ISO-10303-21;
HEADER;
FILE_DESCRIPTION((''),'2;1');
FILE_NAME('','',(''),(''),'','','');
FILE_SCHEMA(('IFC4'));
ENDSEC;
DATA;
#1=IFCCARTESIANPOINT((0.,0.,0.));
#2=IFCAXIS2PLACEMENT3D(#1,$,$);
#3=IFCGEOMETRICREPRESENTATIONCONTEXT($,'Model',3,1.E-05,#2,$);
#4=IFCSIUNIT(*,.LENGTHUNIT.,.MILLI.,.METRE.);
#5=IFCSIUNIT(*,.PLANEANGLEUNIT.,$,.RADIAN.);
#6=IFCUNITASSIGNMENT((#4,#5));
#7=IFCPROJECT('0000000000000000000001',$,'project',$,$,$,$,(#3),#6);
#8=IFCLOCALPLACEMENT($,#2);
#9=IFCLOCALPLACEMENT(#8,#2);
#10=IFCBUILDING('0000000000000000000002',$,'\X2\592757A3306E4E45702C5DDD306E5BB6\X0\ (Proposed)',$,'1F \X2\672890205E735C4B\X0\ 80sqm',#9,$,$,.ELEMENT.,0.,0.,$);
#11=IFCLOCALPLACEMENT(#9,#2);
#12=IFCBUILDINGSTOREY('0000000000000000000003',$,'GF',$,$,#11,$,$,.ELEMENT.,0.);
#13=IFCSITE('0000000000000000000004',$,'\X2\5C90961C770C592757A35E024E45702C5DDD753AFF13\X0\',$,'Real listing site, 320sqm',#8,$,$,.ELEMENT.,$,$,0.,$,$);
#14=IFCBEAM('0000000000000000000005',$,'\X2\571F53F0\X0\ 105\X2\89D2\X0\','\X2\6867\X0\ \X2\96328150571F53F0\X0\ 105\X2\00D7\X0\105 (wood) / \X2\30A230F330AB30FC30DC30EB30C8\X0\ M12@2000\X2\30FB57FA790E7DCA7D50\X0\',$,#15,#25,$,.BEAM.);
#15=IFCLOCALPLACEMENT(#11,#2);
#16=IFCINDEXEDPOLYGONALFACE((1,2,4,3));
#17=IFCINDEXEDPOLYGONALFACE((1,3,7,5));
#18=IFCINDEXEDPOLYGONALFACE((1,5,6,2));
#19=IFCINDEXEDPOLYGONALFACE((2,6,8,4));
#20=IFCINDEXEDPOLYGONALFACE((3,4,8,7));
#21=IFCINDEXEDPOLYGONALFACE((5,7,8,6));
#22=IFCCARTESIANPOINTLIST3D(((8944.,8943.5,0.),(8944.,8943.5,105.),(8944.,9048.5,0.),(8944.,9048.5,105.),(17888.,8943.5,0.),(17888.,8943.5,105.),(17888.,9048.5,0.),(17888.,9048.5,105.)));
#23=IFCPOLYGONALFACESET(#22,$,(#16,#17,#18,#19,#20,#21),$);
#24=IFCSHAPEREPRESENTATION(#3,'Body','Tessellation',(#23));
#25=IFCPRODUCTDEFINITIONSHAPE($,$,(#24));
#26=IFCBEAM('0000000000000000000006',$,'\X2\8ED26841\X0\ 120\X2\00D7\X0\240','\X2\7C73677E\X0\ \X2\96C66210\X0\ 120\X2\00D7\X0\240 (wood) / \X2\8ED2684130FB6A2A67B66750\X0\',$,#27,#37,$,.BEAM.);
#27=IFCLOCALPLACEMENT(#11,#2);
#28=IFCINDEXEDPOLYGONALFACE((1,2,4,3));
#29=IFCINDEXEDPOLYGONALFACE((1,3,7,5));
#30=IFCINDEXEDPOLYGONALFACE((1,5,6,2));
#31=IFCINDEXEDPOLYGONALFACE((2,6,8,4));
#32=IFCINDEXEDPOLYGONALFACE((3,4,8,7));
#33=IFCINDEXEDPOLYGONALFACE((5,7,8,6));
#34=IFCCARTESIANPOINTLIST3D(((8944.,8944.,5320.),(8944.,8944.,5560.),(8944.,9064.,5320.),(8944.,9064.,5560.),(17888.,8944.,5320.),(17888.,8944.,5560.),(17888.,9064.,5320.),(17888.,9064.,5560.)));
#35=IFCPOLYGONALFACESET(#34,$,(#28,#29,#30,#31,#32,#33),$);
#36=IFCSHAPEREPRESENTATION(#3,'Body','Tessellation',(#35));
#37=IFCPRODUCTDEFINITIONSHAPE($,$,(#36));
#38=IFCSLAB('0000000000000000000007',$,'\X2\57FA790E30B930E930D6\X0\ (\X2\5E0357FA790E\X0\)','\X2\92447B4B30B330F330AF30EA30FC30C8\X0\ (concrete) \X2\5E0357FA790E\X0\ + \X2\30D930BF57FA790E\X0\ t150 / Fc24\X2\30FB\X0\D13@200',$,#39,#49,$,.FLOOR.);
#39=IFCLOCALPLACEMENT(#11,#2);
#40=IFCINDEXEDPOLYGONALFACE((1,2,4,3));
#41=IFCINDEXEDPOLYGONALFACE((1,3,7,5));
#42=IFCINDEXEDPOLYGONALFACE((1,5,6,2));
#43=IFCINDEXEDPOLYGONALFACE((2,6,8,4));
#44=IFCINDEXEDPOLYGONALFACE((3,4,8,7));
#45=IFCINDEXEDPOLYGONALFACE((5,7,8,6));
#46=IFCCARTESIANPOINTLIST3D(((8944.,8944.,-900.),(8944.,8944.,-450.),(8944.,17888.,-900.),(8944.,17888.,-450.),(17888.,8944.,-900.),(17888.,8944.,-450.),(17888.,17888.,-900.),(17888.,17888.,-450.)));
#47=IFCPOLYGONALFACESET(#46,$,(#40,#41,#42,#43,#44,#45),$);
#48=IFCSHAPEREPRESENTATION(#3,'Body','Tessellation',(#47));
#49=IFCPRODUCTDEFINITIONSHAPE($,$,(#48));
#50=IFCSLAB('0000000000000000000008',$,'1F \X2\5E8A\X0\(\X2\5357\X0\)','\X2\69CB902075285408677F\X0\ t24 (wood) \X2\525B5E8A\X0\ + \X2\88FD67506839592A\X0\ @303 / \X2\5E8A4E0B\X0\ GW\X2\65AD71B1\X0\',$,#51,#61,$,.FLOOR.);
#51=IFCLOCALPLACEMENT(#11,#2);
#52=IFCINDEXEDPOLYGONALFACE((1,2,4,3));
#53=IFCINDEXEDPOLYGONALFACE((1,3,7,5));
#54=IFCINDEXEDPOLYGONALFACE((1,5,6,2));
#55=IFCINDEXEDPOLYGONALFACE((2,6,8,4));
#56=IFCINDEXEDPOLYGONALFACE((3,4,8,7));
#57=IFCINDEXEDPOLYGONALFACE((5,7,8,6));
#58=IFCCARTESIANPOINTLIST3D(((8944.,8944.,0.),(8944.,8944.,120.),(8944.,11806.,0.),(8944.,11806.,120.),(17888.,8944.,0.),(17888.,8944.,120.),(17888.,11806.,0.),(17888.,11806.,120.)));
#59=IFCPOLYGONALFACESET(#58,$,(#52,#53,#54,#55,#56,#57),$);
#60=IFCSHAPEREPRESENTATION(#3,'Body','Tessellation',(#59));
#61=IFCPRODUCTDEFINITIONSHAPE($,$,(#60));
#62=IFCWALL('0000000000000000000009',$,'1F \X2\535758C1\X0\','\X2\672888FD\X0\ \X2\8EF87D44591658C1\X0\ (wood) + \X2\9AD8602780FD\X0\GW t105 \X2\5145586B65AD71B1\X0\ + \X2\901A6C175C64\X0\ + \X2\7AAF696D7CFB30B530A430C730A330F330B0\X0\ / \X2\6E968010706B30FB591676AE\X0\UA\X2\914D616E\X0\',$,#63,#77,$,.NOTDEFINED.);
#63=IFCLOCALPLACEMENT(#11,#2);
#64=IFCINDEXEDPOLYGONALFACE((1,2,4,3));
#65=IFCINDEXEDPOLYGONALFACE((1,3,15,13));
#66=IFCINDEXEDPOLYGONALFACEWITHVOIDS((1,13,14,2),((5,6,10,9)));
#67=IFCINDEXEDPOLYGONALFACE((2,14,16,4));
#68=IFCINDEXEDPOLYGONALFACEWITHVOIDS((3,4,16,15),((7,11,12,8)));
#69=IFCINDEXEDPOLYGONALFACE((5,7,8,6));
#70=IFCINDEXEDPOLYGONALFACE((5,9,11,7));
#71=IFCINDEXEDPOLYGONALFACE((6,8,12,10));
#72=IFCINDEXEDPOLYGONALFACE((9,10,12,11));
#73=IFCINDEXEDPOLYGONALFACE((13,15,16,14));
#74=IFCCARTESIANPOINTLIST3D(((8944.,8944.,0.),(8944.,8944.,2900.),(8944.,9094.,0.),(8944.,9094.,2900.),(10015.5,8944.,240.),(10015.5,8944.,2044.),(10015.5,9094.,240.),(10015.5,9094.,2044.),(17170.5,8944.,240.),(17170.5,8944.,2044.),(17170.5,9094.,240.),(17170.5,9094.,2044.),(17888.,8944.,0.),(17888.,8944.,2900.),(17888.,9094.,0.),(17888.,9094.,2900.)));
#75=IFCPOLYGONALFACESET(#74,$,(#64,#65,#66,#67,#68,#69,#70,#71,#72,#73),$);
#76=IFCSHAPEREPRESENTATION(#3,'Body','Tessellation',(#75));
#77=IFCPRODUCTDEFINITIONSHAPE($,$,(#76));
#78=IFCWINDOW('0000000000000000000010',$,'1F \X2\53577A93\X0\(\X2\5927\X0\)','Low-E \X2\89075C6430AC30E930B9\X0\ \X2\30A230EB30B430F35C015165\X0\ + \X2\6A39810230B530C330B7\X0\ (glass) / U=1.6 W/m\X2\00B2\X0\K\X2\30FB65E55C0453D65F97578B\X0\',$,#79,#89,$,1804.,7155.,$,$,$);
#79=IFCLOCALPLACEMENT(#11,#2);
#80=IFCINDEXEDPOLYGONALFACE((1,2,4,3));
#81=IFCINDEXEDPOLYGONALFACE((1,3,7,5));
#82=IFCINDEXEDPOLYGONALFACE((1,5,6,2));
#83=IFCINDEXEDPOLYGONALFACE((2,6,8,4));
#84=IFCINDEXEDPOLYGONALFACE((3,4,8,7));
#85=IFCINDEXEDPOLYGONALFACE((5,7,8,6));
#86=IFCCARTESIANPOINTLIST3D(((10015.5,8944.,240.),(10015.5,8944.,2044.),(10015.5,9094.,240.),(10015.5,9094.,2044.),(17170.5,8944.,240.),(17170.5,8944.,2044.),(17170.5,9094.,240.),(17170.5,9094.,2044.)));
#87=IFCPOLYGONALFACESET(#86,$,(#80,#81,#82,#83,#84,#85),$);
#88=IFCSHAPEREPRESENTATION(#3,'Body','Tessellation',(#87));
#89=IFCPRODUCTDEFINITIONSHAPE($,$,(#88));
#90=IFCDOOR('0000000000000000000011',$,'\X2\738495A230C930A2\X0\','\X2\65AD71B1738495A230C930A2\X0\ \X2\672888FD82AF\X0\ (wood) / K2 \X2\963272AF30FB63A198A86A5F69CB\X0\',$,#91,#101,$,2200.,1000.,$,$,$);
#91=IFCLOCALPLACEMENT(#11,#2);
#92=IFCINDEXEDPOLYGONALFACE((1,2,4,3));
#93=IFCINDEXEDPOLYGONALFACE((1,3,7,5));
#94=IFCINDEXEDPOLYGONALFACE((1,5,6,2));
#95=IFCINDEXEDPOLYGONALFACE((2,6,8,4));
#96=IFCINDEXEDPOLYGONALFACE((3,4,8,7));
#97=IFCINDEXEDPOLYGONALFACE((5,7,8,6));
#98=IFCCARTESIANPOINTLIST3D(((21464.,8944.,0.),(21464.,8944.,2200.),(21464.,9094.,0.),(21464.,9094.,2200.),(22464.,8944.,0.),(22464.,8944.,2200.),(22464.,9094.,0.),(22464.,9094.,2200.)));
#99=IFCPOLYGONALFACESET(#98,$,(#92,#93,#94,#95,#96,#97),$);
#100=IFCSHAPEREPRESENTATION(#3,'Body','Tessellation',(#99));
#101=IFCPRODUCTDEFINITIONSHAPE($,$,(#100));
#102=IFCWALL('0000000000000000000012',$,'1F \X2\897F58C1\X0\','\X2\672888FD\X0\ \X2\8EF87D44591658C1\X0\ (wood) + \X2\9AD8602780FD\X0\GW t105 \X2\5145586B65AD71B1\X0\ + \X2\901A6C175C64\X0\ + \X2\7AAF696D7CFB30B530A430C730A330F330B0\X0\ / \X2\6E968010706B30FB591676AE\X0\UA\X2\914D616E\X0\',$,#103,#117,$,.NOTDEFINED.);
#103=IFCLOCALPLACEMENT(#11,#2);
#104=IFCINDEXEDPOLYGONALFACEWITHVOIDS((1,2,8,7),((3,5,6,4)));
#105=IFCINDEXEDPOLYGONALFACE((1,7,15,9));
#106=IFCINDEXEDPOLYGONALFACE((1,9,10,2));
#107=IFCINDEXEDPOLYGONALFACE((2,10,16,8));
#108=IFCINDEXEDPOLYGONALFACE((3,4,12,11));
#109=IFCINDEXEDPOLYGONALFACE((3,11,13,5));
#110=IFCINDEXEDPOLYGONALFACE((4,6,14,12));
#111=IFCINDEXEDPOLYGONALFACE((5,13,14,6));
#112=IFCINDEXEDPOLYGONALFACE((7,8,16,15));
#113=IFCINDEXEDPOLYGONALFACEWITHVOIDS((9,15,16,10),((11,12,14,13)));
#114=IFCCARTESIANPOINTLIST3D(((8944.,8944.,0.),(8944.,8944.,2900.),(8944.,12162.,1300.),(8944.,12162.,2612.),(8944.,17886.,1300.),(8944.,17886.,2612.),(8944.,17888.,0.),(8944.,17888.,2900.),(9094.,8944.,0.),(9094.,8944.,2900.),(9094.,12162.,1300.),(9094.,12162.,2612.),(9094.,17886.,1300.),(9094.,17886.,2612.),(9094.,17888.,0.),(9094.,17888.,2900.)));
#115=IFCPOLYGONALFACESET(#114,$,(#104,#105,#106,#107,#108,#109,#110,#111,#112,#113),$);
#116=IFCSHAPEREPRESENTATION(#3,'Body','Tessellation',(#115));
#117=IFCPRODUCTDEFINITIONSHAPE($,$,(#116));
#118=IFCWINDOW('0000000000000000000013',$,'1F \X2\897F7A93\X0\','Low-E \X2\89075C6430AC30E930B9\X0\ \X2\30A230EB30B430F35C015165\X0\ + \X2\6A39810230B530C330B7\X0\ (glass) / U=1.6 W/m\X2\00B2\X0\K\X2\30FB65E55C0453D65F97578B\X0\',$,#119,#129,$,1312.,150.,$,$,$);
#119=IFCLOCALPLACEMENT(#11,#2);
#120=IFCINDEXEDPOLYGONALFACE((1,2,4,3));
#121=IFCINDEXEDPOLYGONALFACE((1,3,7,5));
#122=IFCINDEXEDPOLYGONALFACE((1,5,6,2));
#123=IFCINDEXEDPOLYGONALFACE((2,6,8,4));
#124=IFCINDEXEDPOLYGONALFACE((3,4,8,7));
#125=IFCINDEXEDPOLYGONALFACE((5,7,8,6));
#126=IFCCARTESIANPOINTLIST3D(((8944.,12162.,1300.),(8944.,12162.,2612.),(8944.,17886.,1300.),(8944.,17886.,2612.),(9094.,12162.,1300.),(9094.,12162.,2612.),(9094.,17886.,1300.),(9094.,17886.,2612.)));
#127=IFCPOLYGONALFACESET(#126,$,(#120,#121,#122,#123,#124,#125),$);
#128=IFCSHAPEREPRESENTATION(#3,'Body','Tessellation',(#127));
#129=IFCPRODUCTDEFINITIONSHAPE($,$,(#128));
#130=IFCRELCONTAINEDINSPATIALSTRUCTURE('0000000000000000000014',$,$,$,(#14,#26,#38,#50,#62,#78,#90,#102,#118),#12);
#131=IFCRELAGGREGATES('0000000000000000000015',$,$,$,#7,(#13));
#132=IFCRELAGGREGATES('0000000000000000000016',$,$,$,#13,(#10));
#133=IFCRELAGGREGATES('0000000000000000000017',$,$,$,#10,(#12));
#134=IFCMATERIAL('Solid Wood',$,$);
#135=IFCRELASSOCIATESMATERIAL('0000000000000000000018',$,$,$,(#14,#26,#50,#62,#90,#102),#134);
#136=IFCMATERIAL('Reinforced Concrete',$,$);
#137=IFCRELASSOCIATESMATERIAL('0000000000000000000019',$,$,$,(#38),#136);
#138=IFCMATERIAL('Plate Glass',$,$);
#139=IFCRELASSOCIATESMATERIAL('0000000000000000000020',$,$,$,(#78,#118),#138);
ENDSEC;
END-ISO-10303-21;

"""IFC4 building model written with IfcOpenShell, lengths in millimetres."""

from ifc_helpers import new_model, si_unit, frame, frame_2d, origin, place, context, project, spatial, rectangle, extrude, material, element, fill, save


model = new_model("IFC4")

# Units and contexts
model_context = context("Model", 3, precision=1e-05, world=origin())
ifc_project = project(units=[si_unit("LENGTHUNIT", "METRE", prefix="MILLI"), si_unit("PLANEANGLEUNIT", "RADIAN")], contexts=[model_context])

# Site, building, storey
site_placement = place(None, origin())
site = spatial("IfcSite", under=ifc_project, at=site_placement, Name="岐阜県大垣市久瀬川町３", ObjectType="Real listing site, 320sqm", CompositionType="ELEMENT", RefElevation=0.0)
building_placement = place(site_placement, origin())
building = spatial("IfcBuilding", under=site, at=building_placement, Name="大垣の久瀬川の家 (Proposed)", ObjectType="1F 木造平屋 80sqm", CompositionType="ELEMENT", ElevationOfRefHeight=0.0, ElevationOfTerrain=0.0)
storey_placement = place(building_placement, origin())
storey = spatial("IfcBuildingStorey", under=building, at=storey_placement, Name="GF", CompositionType="ELEMENT", Elevation=0.0)

# Shared definitions
ifc_material_1 = material(Name="Solid Wood")

# Beams
beam_1_placement = place(storey_placement, frame((4472.0, 4472.0, 0.0)))
element("IfcBeam", 1, at=beam_1_placement, inside=storey, material=ifc_material_1, Name="土台 105角", Description="桧 防腐土台 105×105 (wood) / アンカーボルト M12@2000・基礎緊結", PredefinedType="BEAM", context=model_context, shape_type="SweptSolid", body=[
    extrude(rectangle(XDim=8944.0, YDim=105.0, at=frame_2d((4472.0, 52.0))), frame((4472.0, 4472.0, 0.0)), (0.0, 0.0, 1.0), 105.0),
])
beam_2_placement = place(storey_placement, frame((4472.0, 4472.0, 2660.0)))
element("IfcBeam", 2, at=beam_2_placement, inside=storey, material=ifc_material_1, Name="軒桁 120×240", Description="米松 集成 120×240 (wood) / 軒桁・横架材", PredefinedType="BEAM", context=model_context, shape_type="SweptSolid", body=[
    extrude(rectangle(XDim=8944.0, YDim=120.0, at=frame_2d((4472.0, 60.0))), frame((4472.0, 4472.0, 2660.0)), (0.0, 0.0, 1.0), 240.0),
])

# Slabs
ifc_material_2 = material(Name="Reinforced Concrete")
slab_1_placement = place(storey_placement, frame((4472.0, 4472.0, -450.0)))
element("IfcSlab", 3, at=slab_1_placement, inside=storey, material=ifc_material_2, Name="基礎スラブ (布基礎)", Description="鉄筋コンクリート (concrete) 布基礎 + ベタ基礎 t150 / Fc24・D13@200", PredefinedType="FLOOR", context=model_context, shape_type="SweptSolid", body=[
    extrude(rectangle(XDim=8944.0, YDim=8944.0, at=frame_2d((4472.0, 4472.0))), frame((4472.0, 4472.0, -450.0)), (0.0, 0.0, 1.0), 450.0),
])
slab_2_placement = place(storey_placement, frame((4472.0, 4472.0, 0.0)))
element("IfcSlab", 4, at=slab_2_placement, inside=storey, material=ifc_material_1, Name="1F 床(南)", Description="構造用合板 t24 (wood) 剛床 + 製材根太 @303 / 床下 GW断熱", PredefinedType="FLOOR", context=model_context, shape_type="SweptSolid", body=[
    extrude(rectangle(XDim=8944.0, YDim=2862.0, at=frame_2d((4472.0, 1431.0))), frame((4472.0, 4472.0, 0.0)), (0.0, 0.0, 1.0), 120.0),
])

# Wall, openings, window, door
wall_1_placement = place(storey_placement, frame((4472.0, 4472.0, 0.0)))
wall_1 = element("IfcWall", 5, at=wall_1_placement, inside=storey, material=ifc_material_1, Name="1F 南壁", Description="木製 軸組外壁 (wood) + 高性能GW t105 充填断熱 + 通気層 + 窯業系サイディング / 準耐火・外皮UA配慮", PredefinedType="NOTDEFINED", context=model_context, shape_type="SweptSolid", body=[
    extrude(rectangle(XDim=8944.0, YDim=150.0, at=frame_2d((4472.0, 75.0))), frame((4472.0, 4472.0, 0.0)), (0.0, 0.0, 1.0), 2900.0),
])
opening_1_placement = place(storey_placement, frame((5008.0, 4472.0, 120.0)))
opening_1 = element("IfcOpeningElement", 6, at=opening_1_placement, cuts=wall_1, PredefinedType="NOTDEFINED", context=model_context, shape_type="SweptSolid", body=[
    extrude(rectangle(XDim=7155.0, YDim=150.0, at=frame_2d((3577.0, 75.0))), frame((5008.0, 4472.0, 120.0)), (0.0, 0.0, 1.0), 1804.0),
])
opening_2_placement = place(storey_placement, frame((10732.0, 4472.0, 0.0)))
opening_2 = element("IfcOpeningElement", 7, at=opening_2_placement, cuts=wall_1, PredefinedType="NOTDEFINED", context=model_context, shape_type="SweptSolid", body=[
    extrude(rectangle(XDim=1000.0, YDim=150.0, at=frame_2d((500.0, 75.0))), frame((10732.0, 4472.0, 0.0)), (0.0, 0.0, 1.0), 2200.0),
])
ifc_material_3 = material(Name="Plate Glass")
window_1_placement = place(storey_placement, frame((5008.0, 4472.0, 120.0)))
window_1 = element("IfcWindow", 8, at=window_1_placement, inside=storey, material=ifc_material_3, Name="1F 南窓(大)", Description="Low-E 複層ガラス アルゴン封入 + 樹脂サッシ (glass) / U=1.6 W/m²K・日射取得型", OverallHeight=1804.0, OverallWidth=7155.0, context=model_context, shape_type="SweptSolid", body=[
    extrude(rectangle(XDim=7155.0, YDim=150.0, at=frame_2d((3577.0, 75.0))), frame((5008.0, 4472.0, 120.0)), (0.0, 0.0, 1.0), 1804.0),
])
fill(opening_1, window_1)
door_placement = place(storey_placement, frame((10732.0, 4472.0, 0.0)))
door = element("IfcDoor", 9, at=door_placement, inside=storey, material=ifc_material_1, Name="玄関ドア", Description="断熱玄関ドア 木製芯 (wood) / K2 防犯・採風機構", OverallHeight=2200.0, OverallWidth=1000.0, context=model_context, shape_type="SweptSolid", body=[
    extrude(rectangle(XDim=1000.0, YDim=150.0, at=frame_2d((500.0, 75.0))), frame((10732.0, 4472.0, 0.0)), (0.0, 0.0, 1.0), 2200.0),
])
fill(opening_2, door)

# Wall, opening, window
wall_2_placement = place(storey_placement, frame((4472.0, 4472.0, 0.0)))
wall_2 = element("IfcWall", 10, at=wall_2_placement, inside=storey, material=ifc_material_1, Name="1F 西壁", Description="木製 軸組外壁 (wood) + 高性能GW t105 充填断熱 + 通気層 + 窯業系サイディング / 準耐火・外皮UA配慮", PredefinedType="NOTDEFINED", context=model_context, shape_type="SweptSolid", body=[
    extrude(rectangle(XDim=150.0, YDim=8944.0, at=frame_2d((75.0, 4472.0))), frame((4472.0, 4472.0, 0.0)), (0.0, 0.0, 1.0), 2900.0),
])
opening_3_placement = place(storey_placement, frame((4472.0, 6081.0, 650.0)))
opening_3 = element("IfcOpeningElement", 11, at=opening_3_placement, cuts=wall_2, PredefinedType="NOTDEFINED", context=model_context, shape_type="SweptSolid", body=[
    extrude(rectangle(XDim=150.0, YDim=5724.0, at=frame_2d((75.0, 2862.0))), frame((4472.0, 6081.0, 650.0)), (0.0, 0.0, 1.0), 1312.0),
])
window_2_placement = place(storey_placement, frame((4472.0, 6081.0, 650.0)))
window_2 = element("IfcWindow", 12, at=window_2_placement, inside=storey, material=ifc_material_3, Name="1F 西窓", Description="Low-E 複層ガラス アルゴン封入 + 樹脂サッシ (glass) / U=1.6 W/m²K・日射取得型", OverallHeight=1312.0, OverallWidth=150.0, context=model_context, shape_type="SweptSolid", body=[
    extrude(rectangle(XDim=150.0, YDim=5724.0, at=frame_2d((75.0, 2862.0))), frame((4472.0, 6081.0, 650.0)), (0.0, 0.0, 1.0), 1312.0),
])
fill(opening_3, window_2)

save(model, "model.ifc")
